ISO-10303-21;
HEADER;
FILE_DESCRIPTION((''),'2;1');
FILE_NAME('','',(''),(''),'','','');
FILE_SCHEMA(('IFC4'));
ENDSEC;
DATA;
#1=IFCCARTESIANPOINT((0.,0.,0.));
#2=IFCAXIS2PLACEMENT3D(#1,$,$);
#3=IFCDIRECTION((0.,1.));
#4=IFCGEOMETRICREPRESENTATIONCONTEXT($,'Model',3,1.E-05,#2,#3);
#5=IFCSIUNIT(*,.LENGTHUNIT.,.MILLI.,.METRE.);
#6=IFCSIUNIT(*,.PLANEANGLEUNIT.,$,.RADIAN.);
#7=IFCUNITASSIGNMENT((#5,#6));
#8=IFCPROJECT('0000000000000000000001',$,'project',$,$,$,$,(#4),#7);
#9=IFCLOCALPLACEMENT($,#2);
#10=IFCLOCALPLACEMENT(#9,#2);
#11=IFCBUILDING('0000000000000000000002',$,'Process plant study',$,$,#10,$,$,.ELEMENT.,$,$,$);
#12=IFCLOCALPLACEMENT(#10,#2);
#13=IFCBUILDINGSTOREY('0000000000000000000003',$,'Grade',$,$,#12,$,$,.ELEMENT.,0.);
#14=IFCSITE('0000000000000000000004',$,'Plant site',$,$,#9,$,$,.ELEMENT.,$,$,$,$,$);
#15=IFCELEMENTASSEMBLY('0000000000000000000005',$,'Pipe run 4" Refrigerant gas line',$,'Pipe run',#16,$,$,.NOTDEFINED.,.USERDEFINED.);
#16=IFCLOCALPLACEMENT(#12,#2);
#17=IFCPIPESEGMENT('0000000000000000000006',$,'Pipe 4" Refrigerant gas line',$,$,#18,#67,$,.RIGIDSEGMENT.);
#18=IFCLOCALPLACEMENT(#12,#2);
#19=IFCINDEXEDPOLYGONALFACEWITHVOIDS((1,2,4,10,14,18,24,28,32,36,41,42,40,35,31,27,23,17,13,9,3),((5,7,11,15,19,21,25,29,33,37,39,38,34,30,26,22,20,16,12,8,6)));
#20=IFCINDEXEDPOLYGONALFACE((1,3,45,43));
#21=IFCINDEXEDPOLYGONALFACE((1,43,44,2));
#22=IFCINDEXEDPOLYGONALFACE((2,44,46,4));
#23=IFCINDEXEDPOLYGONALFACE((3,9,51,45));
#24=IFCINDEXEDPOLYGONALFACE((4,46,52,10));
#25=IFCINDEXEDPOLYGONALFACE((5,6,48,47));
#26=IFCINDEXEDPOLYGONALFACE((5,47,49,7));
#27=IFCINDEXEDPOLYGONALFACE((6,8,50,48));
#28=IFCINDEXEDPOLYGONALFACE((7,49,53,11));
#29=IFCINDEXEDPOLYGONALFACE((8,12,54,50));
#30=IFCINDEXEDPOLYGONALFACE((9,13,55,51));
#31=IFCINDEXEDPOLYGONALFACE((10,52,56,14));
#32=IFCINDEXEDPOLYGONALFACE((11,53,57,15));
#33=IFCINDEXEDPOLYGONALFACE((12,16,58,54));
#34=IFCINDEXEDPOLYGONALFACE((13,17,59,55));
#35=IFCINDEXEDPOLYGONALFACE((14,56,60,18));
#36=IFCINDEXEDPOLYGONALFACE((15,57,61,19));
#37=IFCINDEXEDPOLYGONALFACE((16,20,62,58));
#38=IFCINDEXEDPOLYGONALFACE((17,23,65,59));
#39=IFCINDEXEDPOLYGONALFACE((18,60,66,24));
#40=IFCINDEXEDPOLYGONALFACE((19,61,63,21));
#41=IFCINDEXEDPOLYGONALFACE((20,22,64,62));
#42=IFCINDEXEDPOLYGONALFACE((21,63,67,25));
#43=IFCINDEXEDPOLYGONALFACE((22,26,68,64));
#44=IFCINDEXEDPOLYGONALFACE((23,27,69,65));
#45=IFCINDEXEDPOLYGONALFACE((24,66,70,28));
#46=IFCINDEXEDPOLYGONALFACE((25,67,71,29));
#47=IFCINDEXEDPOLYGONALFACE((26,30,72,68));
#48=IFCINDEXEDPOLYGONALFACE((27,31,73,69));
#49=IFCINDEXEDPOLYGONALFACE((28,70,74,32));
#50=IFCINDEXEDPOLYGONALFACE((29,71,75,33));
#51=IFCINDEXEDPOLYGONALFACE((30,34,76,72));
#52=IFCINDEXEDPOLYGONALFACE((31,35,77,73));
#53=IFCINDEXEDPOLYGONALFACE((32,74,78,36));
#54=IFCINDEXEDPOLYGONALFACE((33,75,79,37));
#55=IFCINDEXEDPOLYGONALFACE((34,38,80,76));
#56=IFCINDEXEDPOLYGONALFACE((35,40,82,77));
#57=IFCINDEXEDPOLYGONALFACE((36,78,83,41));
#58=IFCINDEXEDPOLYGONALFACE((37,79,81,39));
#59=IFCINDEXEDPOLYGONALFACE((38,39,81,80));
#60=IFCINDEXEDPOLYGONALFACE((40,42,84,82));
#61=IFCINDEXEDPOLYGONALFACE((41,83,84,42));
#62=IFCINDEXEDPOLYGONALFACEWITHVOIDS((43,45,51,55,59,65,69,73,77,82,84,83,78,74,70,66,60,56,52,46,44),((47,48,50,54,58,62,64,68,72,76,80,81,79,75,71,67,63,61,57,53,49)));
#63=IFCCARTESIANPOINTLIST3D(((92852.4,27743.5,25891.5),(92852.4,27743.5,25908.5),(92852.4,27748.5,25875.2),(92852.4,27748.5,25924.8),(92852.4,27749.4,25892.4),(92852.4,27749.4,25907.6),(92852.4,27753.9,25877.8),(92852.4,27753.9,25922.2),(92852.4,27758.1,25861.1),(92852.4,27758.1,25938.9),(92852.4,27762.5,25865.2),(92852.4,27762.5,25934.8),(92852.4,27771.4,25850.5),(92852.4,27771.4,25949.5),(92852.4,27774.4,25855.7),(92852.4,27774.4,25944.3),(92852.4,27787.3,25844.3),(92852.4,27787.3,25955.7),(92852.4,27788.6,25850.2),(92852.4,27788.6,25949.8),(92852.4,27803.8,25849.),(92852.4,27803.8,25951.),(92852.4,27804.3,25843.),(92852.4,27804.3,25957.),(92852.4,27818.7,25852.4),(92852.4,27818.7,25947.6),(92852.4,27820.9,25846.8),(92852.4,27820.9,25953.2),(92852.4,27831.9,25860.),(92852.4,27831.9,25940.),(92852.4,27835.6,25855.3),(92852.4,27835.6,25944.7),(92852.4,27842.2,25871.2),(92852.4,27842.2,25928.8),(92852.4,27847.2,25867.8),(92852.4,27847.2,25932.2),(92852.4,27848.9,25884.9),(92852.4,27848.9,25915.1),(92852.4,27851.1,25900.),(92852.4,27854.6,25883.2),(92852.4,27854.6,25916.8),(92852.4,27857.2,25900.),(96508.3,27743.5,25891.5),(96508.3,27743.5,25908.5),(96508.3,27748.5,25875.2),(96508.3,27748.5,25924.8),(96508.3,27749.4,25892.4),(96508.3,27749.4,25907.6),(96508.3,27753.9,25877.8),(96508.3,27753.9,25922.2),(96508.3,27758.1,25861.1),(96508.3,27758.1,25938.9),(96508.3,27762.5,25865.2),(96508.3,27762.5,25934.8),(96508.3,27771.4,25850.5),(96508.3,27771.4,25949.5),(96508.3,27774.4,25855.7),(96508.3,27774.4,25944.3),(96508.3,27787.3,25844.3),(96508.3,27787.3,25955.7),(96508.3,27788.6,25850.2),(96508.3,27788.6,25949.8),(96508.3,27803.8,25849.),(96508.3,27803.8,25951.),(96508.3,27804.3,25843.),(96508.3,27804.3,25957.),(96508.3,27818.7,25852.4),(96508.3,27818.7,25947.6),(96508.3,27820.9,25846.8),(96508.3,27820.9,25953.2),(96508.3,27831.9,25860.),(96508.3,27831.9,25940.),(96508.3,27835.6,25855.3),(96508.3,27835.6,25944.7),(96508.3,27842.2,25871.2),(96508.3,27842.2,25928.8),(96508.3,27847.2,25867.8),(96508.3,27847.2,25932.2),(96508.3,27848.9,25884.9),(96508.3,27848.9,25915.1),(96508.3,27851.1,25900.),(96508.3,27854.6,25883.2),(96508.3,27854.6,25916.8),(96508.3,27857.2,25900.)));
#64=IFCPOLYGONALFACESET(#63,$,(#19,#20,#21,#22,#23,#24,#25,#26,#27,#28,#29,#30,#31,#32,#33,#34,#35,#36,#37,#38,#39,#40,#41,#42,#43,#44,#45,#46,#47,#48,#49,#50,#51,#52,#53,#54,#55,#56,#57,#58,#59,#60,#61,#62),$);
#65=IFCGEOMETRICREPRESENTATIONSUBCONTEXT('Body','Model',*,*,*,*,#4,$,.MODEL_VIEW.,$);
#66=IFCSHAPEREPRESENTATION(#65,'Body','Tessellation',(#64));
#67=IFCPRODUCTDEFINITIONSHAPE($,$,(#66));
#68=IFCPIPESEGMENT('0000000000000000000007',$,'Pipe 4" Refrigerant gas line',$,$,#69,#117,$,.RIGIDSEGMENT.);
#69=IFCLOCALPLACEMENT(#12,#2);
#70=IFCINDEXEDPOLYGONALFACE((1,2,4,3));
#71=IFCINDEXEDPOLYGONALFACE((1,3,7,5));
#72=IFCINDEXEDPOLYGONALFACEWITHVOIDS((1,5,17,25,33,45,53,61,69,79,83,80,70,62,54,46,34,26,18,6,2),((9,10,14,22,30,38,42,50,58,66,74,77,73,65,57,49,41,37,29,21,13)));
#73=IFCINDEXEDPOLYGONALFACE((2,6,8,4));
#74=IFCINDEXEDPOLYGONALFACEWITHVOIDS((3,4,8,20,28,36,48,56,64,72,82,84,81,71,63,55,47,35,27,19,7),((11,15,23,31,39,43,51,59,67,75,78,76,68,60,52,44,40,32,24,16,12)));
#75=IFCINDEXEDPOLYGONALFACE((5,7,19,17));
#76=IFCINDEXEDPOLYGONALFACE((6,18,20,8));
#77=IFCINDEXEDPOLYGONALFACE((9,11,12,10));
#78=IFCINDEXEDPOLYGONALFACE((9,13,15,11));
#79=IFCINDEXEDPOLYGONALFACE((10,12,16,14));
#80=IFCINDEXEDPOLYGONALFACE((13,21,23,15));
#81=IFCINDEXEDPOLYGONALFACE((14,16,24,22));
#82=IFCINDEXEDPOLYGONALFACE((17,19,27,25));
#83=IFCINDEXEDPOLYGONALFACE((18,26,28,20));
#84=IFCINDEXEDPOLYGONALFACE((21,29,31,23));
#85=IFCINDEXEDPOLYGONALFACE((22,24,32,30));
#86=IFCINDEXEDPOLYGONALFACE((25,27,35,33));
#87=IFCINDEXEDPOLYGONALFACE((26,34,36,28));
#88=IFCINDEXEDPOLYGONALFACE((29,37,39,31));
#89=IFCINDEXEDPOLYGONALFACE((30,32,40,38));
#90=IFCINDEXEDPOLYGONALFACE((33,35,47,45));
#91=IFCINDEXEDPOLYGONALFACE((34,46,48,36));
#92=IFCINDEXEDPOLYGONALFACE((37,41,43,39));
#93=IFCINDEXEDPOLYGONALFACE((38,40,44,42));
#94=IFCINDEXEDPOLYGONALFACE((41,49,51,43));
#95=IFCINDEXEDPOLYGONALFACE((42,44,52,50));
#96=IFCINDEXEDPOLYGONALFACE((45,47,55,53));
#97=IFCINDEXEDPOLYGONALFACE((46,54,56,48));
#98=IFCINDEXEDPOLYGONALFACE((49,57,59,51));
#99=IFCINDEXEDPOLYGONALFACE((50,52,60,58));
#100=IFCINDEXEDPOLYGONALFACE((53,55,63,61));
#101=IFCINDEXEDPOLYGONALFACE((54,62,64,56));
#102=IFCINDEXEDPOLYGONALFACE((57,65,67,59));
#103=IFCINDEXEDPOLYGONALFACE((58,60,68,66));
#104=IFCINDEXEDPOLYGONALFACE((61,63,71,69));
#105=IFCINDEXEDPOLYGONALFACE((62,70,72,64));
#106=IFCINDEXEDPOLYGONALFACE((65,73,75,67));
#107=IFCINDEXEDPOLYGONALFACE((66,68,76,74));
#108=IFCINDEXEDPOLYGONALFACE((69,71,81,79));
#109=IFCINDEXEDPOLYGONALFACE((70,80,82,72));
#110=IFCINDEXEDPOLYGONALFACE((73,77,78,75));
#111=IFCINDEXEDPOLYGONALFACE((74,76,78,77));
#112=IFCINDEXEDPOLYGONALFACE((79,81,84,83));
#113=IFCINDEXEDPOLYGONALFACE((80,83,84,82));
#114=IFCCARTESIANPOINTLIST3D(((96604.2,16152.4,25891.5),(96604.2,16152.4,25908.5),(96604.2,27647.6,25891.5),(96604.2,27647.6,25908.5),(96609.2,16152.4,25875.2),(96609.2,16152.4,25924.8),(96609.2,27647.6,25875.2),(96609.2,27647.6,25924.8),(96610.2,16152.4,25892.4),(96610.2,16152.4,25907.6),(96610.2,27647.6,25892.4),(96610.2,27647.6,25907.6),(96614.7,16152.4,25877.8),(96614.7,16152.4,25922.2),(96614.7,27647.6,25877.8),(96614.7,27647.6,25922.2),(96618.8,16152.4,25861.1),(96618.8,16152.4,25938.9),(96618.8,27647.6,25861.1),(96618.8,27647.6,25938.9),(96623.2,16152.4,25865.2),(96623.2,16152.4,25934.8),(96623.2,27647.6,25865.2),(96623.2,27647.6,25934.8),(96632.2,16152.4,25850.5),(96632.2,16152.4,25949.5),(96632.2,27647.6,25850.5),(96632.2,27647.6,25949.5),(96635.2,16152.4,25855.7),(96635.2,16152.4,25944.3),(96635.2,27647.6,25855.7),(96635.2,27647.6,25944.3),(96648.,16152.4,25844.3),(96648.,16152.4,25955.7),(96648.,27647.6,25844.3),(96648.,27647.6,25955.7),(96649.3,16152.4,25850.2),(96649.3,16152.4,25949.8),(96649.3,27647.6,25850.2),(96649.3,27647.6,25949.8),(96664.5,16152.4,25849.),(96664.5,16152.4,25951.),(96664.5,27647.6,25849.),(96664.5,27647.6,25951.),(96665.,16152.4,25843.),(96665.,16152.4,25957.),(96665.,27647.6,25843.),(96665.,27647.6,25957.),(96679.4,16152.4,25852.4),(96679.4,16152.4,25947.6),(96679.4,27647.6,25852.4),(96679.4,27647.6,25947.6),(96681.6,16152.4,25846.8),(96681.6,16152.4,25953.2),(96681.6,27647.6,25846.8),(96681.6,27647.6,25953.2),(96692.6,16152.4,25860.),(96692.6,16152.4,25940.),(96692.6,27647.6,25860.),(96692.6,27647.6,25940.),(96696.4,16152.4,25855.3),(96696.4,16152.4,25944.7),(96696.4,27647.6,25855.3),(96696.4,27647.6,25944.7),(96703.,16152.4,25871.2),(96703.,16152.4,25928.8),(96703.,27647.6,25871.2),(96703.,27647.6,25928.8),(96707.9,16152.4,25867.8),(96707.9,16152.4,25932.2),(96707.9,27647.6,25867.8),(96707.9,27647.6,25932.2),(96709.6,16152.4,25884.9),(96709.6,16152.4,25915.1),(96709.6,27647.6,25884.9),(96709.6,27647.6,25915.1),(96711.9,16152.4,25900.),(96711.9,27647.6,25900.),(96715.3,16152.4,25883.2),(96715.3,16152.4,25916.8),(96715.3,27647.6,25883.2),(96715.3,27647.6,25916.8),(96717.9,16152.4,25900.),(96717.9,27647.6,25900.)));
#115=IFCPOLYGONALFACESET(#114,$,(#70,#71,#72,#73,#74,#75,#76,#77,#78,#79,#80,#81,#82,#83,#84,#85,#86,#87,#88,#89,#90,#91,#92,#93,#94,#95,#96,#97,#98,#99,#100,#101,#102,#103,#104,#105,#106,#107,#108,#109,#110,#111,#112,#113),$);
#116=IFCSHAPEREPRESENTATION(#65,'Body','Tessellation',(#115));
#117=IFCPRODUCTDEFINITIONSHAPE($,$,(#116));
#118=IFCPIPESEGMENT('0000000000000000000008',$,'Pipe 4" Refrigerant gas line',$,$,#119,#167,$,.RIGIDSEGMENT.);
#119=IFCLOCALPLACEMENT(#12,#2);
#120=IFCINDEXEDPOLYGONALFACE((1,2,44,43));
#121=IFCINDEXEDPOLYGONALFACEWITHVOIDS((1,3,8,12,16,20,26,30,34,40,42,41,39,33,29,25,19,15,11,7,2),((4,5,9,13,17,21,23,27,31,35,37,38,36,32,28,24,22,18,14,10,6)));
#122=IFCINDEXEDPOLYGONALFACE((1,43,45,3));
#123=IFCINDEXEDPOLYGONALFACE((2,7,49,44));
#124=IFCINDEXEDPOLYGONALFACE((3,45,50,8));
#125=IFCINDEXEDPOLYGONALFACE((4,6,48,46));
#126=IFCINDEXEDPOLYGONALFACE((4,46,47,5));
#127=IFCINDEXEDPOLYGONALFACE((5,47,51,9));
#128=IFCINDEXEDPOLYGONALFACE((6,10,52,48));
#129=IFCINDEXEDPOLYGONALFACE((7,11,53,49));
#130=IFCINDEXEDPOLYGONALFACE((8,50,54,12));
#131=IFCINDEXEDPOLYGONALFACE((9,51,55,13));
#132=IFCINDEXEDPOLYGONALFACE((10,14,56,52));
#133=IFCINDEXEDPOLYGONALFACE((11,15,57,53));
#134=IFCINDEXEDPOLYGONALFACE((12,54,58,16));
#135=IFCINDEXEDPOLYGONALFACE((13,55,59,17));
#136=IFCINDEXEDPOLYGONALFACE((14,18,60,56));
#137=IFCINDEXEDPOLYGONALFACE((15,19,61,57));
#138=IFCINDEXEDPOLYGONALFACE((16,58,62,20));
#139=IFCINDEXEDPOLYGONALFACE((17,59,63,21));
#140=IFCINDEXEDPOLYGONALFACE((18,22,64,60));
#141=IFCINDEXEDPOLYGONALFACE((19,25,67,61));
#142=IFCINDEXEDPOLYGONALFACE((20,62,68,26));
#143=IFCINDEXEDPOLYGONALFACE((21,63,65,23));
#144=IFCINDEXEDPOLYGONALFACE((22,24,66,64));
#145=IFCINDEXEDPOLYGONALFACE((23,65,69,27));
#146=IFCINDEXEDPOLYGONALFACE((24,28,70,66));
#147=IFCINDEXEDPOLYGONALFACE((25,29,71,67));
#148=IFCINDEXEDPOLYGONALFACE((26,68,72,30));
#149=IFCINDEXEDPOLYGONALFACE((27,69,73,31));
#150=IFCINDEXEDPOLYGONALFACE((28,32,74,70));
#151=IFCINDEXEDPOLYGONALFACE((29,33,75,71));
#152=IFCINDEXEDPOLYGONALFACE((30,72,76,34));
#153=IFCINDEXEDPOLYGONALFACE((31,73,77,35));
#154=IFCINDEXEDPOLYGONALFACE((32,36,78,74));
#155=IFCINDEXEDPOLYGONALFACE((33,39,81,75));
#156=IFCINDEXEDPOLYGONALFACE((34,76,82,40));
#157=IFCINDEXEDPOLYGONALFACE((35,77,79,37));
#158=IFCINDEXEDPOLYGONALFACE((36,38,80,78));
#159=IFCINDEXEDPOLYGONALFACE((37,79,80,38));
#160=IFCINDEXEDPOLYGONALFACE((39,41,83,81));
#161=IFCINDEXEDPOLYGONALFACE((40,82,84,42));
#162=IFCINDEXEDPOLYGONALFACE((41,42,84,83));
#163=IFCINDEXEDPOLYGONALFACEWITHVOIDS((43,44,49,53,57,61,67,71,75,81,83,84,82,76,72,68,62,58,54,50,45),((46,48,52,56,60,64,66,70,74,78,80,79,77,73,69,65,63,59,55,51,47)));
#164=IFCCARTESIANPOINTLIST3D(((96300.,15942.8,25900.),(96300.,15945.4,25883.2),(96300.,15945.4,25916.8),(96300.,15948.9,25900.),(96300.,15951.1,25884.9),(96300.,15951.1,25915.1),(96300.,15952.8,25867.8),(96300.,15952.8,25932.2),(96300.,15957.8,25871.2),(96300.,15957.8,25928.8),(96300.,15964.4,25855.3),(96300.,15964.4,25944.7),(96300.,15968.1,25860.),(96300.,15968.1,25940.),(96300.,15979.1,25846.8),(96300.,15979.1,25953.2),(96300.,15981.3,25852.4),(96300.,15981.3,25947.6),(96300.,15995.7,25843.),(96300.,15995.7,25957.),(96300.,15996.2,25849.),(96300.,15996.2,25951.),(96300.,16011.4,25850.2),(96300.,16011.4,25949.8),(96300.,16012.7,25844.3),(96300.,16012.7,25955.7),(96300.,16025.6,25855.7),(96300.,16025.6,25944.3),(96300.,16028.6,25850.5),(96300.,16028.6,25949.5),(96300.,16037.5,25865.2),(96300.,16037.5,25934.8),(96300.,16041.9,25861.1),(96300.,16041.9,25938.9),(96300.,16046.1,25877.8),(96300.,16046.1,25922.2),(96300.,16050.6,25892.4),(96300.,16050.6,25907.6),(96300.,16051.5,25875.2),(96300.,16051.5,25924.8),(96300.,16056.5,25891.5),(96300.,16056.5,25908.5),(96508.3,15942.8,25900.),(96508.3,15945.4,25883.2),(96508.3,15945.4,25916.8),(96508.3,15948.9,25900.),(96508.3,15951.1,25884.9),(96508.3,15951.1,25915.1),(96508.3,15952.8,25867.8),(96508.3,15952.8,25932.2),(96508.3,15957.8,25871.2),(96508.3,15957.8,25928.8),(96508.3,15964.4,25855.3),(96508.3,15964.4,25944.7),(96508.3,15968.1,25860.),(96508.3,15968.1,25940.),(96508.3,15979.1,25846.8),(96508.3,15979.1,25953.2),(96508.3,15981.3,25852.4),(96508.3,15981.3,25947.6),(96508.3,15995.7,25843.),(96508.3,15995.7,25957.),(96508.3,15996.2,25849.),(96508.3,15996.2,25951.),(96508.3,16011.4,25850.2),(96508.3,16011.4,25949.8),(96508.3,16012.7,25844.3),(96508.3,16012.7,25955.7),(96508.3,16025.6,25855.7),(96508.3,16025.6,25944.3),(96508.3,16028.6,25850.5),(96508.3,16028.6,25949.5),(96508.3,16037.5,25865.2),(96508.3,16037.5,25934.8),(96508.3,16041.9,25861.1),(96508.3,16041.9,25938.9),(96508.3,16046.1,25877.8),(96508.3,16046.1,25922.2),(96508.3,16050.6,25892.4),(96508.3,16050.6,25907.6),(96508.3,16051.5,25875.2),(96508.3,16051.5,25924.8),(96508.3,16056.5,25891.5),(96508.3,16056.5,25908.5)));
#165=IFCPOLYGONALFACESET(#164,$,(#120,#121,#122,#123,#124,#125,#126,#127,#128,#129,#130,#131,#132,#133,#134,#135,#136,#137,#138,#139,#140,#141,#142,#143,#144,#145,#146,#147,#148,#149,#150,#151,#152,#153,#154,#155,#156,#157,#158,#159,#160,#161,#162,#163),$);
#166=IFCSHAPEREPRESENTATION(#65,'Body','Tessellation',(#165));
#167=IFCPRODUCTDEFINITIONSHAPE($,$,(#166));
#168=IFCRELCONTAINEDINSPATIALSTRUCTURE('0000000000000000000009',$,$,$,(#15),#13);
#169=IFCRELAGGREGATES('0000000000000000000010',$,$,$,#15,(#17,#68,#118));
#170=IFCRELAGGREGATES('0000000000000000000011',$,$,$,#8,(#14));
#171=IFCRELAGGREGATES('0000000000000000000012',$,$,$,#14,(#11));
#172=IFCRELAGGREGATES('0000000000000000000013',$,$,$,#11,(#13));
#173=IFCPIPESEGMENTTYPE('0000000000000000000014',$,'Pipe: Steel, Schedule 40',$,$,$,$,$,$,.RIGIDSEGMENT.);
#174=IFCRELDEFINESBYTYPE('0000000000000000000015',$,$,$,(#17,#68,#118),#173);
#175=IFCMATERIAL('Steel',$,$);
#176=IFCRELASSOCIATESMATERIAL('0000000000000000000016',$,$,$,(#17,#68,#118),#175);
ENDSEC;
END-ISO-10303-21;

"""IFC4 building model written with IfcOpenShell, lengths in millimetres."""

from ifc_helpers import new_model, si_unit, direction, frame, origin, origin_with_axes, origin_2d, place, context, subcontext, project, spatial, hollow_circle, extrude, material, type_object, element, aggregate, save


model = new_model("IFC4")

# Units and contexts
model_context = context("Model", 3, precision=1e-05, world=origin(), true_north=direction((0.0, 1.0)))
body_context = subcontext(model_context, "Body", "Model", "MODEL_VIEW")
ifc_project = project(units=[si_unit("LENGTHUNIT", "METRE", prefix="MILLI"), si_unit("PLANEANGLEUNIT", "RADIAN")], contexts=[model_context])

# Site, building, storey
site_placement = place(None, origin())
site = spatial("IfcSite", under=ifc_project, at=site_placement, Name="Plant site", CompositionType="ELEMENT")
building_placement = place(site_placement, origin())
building = spatial("IfcBuilding", under=site, at=building_placement, Name="Process plant study", CompositionType="ELEMENT")
storey_placement = place(building_placement, origin())
storey = spatial("IfcBuildingStorey", under=building, at=storey_placement, Name="Grade", CompositionType="ELEMENT", Elevation=0.0)

# Element assembly, pipe segments
ifc_material = material(Name="Steel")
pipe_segment_type = type_object("IfcPipeSegmentType", Name="Pipe: Steel, Schedule 40", PredefinedType="RIGIDSEGMENT")
assembly_1_placement = place(storey_placement, origin_with_axes())
assembly_1 = element("IfcElementAssembly", 1, at=assembly_1_placement, inside=storey, Name="Pipe run 4\" Refrigerant gas line", ObjectType="Pipe run", AssemblyPlace="NOTDEFINED", PredefinedType="USERDEFINED")
pipe_segment_1_placement = place(storey_placement, origin_with_axes())
pipe_segment_1 = element("IfcPipeSegment", 2, at=pipe_segment_1_placement, type_object=pipe_segment_type, material=ifc_material, Name="Pipe 4\" Refrigerant gas line", PredefinedType="RIGIDSEGMENT", context=body_context, shape_type="SweptSolid", body=[
    extrude(hollow_circle(Radius=57.1, WallThickness=6.0, at=origin_2d()), frame((92852.4, 27800.0, 25900.0), z_axis=(1.0, 0.0, 0.0), x_axis=(0.0, 1.0, 0.0)), (0.0, 0.0, 1.0), 3655.9),
])
pipe_segment_2_placement = place(storey_placement, origin_with_axes())
pipe_segment_2 = element("IfcPipeSegment", 3, at=pipe_segment_2_placement, type_object=pipe_segment_type, material=ifc_material, Name="Pipe 4\" Refrigerant gas line", PredefinedType="RIGIDSEGMENT", context=body_context, shape_type="SweptSolid", body=[
    extrude(hollow_circle(Radius=57.1, WallThickness=6.0, at=origin_2d()), frame((96660.7, 27647.6, 25900.0), z_axis=(0.0, -1.0, 0.0), x_axis=(1.0, 0.0, 0.0)), (0.0, 0.0, 1.0), 11495.2),
])
pipe_segment_3_placement = place(storey_placement, origin_with_axes())
pipe_segment_3 = element("IfcPipeSegment", 4, at=pipe_segment_3_placement, type_object=pipe_segment_type, material=ifc_material, Name="Pipe 4\" Refrigerant gas line", PredefinedType="RIGIDSEGMENT", context=body_context, shape_type="SweptSolid", body=[
    extrude(hollow_circle(Radius=57.1, WallThickness=6.0, at=origin_2d()), frame((96508.3, 16000.0, 25900.0), z_axis=(-1.0, 0.0, 0.0), x_axis=(0.0, -1.0, 0.0)), (0.0, 0.0, 1.0), 208.3),
])

aggregate(assembly_1, [pipe_segment_1, pipe_segment_2, pipe_segment_3])

save(model, "model.ifc")
